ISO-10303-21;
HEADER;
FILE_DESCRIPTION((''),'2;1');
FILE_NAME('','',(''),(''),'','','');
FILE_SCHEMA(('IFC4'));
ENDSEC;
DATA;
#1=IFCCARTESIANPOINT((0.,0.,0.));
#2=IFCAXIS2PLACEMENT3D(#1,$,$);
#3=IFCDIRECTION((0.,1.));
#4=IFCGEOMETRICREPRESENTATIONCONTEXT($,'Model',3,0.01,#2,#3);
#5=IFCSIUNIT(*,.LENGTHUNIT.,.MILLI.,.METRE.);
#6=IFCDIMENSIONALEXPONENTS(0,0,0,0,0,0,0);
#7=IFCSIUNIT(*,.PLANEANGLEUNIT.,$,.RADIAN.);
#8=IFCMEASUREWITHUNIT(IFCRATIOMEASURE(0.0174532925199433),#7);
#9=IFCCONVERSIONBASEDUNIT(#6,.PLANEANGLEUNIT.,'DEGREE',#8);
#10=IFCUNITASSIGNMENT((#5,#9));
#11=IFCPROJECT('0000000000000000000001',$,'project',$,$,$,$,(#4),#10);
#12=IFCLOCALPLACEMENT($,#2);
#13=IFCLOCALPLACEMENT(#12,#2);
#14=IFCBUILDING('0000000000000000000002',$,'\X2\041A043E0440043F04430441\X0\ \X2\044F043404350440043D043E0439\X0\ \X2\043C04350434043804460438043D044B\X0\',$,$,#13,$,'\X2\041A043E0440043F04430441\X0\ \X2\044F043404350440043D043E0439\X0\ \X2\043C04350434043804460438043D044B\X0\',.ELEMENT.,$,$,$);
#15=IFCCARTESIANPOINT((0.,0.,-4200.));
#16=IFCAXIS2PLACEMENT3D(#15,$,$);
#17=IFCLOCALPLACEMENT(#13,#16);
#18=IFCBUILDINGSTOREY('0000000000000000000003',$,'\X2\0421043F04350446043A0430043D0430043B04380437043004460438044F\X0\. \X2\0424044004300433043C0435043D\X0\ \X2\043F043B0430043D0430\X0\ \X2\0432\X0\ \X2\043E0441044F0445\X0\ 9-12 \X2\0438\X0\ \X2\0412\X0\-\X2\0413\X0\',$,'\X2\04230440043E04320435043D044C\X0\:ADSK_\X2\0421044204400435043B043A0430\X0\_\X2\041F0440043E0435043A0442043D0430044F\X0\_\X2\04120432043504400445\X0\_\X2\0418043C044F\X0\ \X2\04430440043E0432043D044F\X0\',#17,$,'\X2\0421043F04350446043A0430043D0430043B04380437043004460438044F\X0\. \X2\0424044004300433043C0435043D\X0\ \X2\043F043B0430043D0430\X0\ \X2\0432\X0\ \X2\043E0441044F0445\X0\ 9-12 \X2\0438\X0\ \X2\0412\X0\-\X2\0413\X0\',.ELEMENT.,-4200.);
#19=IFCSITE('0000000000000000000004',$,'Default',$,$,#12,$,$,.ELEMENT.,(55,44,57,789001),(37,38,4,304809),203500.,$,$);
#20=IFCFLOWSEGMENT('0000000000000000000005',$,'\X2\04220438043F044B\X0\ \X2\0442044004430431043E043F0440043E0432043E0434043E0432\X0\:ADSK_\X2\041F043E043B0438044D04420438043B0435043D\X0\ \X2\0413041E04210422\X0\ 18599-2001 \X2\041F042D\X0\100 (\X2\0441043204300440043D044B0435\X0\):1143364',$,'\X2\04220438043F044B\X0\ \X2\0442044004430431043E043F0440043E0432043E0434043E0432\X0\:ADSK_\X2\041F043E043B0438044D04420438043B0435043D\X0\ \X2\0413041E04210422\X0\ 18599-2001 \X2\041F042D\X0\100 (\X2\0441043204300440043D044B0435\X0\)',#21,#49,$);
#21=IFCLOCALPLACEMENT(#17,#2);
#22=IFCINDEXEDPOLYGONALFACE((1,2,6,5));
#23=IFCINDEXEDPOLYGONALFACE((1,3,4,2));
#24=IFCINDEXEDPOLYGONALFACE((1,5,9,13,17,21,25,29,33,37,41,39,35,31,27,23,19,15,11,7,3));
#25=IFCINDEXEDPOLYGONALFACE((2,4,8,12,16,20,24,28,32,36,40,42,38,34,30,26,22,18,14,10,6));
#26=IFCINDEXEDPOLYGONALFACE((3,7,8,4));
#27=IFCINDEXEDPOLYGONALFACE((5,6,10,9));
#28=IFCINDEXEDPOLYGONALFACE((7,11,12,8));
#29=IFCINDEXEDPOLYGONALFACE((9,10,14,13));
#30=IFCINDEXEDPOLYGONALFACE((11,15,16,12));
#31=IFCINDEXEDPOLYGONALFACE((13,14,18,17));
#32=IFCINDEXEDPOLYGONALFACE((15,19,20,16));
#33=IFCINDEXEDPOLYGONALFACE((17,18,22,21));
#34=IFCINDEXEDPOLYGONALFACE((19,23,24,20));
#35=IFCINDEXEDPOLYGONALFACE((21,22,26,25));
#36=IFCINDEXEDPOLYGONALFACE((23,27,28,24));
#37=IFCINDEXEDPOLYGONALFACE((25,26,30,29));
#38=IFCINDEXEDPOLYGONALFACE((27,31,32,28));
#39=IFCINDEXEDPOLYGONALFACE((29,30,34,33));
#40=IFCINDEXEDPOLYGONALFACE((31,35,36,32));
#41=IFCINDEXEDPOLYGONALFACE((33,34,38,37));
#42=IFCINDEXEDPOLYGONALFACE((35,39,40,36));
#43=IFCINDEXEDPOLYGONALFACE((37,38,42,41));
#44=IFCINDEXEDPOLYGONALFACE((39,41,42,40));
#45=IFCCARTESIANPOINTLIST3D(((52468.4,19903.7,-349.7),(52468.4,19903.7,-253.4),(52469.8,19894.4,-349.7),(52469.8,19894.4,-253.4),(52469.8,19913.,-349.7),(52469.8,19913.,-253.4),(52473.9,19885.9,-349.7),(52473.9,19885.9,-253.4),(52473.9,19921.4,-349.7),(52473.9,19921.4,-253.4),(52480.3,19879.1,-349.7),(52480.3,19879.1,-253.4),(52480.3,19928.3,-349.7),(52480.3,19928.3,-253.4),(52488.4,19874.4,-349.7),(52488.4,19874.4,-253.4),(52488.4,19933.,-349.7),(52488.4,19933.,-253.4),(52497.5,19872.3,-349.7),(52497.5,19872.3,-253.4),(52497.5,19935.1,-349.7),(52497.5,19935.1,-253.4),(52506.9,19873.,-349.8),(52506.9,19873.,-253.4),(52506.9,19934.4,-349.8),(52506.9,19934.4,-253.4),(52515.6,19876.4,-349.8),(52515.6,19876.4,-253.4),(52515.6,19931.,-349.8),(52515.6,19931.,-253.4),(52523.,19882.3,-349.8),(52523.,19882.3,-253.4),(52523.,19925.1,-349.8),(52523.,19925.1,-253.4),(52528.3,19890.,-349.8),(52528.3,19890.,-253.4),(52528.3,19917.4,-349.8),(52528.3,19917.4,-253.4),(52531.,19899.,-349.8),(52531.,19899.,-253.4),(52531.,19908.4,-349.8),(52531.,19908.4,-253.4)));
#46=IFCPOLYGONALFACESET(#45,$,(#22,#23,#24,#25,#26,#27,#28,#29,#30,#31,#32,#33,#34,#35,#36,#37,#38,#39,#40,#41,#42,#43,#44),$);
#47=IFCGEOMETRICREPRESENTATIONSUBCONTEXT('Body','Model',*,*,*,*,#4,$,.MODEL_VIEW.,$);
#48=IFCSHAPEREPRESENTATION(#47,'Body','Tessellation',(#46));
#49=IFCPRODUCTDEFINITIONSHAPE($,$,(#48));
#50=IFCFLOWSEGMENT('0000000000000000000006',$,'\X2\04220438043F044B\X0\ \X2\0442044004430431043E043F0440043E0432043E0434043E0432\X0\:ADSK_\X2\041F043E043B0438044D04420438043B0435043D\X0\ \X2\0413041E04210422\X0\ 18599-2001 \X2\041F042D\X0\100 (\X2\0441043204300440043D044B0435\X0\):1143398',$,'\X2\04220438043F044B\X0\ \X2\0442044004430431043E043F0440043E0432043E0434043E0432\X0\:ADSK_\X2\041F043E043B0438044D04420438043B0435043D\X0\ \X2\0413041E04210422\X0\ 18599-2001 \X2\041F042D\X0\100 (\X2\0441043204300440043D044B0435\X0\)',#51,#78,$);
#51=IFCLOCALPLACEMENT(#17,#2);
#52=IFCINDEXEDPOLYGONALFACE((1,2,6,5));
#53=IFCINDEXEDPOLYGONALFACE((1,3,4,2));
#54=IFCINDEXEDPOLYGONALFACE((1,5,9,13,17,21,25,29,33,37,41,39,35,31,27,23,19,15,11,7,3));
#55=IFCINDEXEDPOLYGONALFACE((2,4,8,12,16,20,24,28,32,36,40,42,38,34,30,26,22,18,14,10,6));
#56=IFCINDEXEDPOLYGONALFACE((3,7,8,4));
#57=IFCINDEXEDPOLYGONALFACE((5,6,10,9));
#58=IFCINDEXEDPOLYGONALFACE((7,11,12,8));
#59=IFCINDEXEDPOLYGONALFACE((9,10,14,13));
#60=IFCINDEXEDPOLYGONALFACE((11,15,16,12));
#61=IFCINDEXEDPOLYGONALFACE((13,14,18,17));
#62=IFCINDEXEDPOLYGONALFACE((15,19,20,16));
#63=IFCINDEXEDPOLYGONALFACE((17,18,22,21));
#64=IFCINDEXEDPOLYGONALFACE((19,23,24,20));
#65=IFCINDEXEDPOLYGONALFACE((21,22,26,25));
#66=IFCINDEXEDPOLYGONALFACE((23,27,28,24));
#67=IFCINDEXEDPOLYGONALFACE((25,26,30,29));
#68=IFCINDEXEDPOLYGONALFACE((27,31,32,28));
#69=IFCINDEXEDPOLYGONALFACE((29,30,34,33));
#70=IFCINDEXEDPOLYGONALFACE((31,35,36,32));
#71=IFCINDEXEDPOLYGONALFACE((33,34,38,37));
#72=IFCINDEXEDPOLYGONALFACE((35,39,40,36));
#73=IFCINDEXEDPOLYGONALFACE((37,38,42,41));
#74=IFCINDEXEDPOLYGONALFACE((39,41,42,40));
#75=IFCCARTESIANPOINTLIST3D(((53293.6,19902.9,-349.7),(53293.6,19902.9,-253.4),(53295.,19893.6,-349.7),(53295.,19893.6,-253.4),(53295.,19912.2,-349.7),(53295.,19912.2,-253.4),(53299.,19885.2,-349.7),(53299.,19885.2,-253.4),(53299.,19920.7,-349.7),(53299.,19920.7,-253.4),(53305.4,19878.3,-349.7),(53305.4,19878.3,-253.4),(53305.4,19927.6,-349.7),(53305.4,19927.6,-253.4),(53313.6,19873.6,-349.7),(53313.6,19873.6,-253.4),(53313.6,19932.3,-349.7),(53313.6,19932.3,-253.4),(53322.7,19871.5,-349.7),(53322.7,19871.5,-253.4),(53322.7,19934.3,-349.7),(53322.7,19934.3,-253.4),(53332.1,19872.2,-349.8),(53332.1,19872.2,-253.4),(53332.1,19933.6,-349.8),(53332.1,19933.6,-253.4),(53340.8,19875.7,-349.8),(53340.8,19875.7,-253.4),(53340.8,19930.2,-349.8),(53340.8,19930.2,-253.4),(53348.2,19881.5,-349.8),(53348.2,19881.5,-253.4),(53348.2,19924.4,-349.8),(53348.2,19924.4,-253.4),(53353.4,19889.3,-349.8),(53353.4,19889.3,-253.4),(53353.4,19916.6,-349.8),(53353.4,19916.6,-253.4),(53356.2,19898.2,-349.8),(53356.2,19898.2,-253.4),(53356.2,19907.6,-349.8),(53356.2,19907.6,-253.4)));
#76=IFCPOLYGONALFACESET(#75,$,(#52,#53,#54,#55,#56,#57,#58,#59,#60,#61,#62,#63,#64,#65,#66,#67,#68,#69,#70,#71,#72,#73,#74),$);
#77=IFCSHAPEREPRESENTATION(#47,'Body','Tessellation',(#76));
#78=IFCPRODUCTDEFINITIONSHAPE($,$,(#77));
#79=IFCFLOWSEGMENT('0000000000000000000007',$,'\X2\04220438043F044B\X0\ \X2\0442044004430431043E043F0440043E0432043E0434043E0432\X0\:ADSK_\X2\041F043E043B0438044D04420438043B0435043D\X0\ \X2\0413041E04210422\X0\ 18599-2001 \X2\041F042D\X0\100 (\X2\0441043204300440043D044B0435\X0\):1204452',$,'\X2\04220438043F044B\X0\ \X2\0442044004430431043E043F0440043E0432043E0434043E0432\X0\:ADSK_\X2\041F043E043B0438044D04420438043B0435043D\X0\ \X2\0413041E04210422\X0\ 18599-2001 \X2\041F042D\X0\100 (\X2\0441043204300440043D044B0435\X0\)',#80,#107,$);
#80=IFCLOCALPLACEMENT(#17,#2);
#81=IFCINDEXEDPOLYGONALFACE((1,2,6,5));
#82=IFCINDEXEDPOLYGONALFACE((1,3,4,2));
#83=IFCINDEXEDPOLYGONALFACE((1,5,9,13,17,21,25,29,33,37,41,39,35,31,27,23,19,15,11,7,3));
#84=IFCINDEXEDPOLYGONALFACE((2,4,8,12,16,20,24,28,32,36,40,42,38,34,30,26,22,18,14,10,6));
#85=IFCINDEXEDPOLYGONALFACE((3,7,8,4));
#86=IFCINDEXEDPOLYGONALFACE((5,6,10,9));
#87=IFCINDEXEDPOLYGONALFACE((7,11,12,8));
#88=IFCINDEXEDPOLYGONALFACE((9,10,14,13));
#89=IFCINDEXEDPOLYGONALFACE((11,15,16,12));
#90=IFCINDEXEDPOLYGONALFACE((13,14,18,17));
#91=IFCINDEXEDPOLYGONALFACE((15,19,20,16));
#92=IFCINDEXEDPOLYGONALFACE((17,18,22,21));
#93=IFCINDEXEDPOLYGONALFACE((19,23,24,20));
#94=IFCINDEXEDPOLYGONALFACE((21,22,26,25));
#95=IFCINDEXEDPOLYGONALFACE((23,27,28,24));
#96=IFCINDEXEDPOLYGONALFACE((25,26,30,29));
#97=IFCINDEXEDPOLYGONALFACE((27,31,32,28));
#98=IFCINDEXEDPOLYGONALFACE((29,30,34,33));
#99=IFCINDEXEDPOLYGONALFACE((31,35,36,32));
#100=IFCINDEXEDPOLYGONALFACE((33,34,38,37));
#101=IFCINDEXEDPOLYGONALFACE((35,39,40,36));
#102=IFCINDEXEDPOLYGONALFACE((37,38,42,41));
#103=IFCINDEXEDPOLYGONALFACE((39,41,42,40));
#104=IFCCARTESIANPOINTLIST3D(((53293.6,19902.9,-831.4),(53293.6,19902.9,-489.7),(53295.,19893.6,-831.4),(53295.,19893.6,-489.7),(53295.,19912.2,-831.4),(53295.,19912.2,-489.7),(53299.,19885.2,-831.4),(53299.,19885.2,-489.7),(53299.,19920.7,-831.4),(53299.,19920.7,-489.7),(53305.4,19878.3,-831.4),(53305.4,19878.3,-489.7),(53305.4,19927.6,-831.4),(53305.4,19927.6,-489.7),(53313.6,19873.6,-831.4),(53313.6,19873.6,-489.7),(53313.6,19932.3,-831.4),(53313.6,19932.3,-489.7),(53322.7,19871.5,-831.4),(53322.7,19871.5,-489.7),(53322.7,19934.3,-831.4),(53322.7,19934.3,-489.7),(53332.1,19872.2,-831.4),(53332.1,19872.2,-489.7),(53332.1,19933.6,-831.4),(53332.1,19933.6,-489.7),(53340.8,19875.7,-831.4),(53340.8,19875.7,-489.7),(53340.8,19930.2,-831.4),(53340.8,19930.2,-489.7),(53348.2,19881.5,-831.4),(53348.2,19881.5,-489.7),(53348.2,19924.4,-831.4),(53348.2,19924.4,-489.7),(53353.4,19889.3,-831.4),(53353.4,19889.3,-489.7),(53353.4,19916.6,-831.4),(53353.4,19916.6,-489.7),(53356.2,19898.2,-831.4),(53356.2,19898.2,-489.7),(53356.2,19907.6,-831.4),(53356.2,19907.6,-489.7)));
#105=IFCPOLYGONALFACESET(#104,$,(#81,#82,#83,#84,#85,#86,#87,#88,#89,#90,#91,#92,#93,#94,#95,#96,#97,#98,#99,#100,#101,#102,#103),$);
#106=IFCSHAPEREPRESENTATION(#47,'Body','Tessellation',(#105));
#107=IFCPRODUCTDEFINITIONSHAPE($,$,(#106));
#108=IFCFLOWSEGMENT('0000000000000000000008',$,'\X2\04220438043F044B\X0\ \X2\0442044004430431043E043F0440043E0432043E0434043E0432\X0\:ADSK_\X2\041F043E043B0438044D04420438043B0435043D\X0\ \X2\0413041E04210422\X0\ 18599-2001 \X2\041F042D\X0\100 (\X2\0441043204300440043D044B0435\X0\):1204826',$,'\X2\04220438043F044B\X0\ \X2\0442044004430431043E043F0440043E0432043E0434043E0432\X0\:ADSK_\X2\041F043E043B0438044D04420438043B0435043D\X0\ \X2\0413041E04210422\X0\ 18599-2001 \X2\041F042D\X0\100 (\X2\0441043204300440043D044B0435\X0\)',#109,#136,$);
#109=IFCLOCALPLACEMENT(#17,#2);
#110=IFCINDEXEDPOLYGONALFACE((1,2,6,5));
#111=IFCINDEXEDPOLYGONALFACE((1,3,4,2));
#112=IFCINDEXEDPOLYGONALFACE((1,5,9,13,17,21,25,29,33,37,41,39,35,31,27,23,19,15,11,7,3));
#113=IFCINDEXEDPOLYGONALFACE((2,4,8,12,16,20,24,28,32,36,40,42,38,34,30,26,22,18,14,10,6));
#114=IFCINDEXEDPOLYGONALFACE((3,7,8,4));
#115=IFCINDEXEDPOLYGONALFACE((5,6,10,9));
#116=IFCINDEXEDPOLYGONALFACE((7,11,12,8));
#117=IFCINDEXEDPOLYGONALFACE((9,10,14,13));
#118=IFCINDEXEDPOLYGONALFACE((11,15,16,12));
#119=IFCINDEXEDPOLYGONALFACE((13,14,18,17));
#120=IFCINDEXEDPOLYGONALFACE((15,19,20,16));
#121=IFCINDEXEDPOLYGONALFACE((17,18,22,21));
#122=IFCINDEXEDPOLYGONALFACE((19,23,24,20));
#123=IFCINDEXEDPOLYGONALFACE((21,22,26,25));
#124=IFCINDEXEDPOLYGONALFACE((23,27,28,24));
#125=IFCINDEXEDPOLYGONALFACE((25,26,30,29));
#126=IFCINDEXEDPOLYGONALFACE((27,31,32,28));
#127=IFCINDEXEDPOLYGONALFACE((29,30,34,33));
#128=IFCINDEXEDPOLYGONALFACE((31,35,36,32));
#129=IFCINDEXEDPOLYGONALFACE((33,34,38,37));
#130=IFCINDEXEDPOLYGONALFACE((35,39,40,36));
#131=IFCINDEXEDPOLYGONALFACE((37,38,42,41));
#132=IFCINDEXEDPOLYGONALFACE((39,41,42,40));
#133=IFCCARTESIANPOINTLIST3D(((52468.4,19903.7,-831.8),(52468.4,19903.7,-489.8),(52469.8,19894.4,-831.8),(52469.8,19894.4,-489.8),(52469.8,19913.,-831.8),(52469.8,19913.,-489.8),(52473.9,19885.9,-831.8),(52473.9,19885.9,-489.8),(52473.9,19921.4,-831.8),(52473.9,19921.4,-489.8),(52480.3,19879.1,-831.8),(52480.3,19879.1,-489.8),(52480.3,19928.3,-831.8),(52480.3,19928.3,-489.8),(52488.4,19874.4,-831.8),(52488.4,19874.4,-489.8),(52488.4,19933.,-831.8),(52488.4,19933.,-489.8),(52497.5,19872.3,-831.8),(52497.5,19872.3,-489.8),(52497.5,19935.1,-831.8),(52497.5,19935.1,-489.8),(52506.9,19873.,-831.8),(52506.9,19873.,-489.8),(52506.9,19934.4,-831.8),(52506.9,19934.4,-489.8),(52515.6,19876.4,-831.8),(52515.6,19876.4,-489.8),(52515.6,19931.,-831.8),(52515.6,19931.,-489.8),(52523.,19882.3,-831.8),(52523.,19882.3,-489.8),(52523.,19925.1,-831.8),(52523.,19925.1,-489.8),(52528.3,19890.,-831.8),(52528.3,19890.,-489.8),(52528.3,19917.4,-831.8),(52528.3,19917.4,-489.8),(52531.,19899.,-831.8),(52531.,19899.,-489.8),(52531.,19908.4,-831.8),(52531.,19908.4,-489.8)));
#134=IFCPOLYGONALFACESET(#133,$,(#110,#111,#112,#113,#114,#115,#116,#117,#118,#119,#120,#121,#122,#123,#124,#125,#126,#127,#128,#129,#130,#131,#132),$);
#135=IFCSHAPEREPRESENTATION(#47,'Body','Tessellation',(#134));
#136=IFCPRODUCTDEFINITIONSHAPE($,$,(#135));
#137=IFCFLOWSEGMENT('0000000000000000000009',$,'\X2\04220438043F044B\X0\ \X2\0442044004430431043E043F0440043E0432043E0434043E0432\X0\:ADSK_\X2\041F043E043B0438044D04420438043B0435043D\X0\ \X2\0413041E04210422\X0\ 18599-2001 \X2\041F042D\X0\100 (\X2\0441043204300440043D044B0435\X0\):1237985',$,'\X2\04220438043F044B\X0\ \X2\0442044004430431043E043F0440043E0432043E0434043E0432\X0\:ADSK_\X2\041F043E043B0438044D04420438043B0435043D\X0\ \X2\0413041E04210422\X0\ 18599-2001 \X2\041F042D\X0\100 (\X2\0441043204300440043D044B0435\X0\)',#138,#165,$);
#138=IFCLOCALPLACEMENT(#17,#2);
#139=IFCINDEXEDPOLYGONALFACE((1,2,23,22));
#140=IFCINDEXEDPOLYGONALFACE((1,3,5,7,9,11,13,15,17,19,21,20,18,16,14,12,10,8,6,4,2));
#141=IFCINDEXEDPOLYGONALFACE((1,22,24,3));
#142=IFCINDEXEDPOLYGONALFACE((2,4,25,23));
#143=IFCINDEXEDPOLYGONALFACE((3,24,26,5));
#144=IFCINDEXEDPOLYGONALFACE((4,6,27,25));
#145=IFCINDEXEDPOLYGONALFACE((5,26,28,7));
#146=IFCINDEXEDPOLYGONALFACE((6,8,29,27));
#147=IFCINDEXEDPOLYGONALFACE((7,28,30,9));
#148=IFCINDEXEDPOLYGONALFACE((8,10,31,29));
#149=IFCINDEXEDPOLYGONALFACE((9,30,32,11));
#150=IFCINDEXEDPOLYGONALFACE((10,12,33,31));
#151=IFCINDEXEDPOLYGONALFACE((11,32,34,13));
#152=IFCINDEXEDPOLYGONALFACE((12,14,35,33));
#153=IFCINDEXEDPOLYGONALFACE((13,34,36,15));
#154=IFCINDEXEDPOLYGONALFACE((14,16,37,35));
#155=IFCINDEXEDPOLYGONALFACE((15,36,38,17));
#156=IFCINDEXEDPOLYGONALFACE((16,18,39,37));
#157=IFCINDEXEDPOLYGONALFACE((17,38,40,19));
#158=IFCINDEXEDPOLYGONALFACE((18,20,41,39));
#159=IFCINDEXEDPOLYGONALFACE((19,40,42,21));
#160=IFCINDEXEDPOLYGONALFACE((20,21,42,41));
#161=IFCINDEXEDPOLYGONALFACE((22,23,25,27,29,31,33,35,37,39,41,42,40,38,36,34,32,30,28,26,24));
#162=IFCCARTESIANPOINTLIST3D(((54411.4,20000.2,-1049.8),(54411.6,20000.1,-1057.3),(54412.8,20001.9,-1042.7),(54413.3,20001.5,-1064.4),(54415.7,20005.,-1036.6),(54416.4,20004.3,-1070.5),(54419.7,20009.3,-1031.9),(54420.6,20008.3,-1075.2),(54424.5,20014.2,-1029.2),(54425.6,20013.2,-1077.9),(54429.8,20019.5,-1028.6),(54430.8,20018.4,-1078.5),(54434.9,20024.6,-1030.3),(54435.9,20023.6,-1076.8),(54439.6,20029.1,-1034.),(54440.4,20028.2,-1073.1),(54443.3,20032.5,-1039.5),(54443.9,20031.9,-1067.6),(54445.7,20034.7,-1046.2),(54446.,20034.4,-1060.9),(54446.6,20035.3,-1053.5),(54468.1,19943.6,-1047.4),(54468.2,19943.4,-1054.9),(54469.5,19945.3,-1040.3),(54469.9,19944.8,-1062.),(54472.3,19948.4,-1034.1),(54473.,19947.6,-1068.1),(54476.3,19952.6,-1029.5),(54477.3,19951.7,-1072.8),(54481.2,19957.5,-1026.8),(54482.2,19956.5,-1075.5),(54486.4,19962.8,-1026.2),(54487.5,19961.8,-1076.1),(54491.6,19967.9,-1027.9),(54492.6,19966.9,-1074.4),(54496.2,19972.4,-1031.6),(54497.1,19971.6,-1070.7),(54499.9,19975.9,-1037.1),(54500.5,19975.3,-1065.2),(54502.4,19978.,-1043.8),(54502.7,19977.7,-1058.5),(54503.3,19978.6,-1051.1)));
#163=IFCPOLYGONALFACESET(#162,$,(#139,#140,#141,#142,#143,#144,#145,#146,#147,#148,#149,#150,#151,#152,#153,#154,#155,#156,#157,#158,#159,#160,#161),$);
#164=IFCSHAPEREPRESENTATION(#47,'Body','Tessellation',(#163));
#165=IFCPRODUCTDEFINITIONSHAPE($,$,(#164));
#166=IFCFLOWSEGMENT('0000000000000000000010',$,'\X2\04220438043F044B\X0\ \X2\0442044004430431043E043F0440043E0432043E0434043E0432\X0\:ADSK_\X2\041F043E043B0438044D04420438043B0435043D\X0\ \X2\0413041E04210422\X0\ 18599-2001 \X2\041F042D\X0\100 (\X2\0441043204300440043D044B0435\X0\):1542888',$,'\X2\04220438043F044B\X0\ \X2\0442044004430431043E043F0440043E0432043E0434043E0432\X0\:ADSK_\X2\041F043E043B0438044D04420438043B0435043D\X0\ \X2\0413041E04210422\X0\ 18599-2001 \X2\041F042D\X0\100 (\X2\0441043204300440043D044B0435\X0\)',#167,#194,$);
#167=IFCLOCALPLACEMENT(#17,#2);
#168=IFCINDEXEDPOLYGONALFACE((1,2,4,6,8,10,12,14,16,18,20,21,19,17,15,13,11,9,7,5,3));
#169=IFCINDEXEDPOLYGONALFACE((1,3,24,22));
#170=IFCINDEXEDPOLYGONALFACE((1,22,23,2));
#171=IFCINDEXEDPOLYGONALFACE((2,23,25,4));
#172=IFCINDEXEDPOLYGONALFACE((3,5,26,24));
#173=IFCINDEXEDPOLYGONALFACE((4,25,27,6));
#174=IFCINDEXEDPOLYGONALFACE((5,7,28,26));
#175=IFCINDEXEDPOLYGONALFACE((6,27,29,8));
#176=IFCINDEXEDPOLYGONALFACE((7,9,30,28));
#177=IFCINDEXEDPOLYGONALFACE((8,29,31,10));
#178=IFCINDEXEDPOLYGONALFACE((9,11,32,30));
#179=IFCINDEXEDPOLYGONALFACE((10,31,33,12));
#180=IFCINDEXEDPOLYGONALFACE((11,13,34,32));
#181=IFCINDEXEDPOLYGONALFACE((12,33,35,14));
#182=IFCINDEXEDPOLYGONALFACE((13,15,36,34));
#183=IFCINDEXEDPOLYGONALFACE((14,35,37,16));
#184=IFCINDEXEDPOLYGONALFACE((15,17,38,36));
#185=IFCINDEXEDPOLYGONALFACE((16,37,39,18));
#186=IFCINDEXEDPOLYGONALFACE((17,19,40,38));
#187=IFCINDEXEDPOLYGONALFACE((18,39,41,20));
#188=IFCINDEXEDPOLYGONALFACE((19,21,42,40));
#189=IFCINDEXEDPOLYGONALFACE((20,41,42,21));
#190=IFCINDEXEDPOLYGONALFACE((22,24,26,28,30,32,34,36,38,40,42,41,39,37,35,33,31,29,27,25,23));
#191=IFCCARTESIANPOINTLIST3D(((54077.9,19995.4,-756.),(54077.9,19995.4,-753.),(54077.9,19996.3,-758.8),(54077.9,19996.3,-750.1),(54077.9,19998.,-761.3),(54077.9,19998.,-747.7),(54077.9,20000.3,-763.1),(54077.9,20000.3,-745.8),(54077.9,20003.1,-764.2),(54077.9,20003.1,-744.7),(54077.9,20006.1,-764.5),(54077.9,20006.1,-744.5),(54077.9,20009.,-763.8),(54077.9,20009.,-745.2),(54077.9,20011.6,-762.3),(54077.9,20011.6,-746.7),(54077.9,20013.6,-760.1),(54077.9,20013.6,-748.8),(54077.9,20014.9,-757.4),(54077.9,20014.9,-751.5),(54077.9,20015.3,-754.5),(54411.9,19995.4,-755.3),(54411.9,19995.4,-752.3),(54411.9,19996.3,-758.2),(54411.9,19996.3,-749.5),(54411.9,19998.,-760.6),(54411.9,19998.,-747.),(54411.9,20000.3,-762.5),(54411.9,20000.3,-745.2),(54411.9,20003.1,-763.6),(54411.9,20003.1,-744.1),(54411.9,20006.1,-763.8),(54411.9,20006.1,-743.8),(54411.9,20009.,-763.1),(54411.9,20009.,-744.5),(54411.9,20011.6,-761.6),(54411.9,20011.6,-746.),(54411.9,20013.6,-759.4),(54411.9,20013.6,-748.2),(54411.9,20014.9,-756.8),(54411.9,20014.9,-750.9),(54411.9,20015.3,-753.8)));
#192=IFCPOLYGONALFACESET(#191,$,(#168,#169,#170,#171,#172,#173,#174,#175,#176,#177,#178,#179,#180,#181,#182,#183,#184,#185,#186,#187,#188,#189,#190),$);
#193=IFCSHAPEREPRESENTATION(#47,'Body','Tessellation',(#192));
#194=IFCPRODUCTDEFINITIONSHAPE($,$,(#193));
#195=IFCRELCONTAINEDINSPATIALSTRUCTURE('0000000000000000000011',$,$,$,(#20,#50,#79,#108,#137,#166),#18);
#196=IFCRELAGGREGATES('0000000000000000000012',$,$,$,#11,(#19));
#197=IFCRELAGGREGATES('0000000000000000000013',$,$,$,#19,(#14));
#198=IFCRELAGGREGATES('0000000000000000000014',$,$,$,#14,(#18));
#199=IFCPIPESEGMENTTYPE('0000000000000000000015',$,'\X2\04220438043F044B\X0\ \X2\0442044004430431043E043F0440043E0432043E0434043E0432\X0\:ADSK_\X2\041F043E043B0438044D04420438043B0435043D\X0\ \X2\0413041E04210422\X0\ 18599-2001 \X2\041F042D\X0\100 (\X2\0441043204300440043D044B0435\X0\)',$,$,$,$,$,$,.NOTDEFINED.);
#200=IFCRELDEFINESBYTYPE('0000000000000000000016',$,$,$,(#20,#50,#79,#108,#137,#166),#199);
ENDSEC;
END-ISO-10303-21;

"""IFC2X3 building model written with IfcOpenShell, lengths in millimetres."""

from ifc_helpers import new_model, entity, si_unit, converted_unit, direction, frame, origin, origin_2d_with_axis, place, context, subcontext, project, spatial, circle, extrude, type_object, element, save


model = new_model("IFC2X3")

# Units and contexts
model_context = context("Model", 3, precision=0.01, world=origin(), true_north=direction((0.0, 1.0)))
body_context = subcontext(model_context, "Body", "Model", "MODEL_VIEW")
ifc_project = project(units=[si_unit("LENGTHUNIT", "METRE", prefix="MILLI"), converted_unit("PLANEANGLEUNIT", "DEGREE", entity("IfcRatioMeasure", 0.0174532925199433), si_unit("PLANEANGLEUNIT", "RADIAN"), dimensions=[0, 0, 0, 0, 0, 0, 0])], contexts=[model_context])

# Site, building, storey
site_placement = place(None, origin())
site = spatial("IfcSite", under=ifc_project, at=site_placement, Name="Default", CompositionType="ELEMENT", RefLatitude=(55, 44, 57, 789001), RefLongitude=(37, 38, 4, 304809), RefElevation=203500.0)
building_placement = place(site_placement, origin())
building = spatial("IfcBuilding", under=site, at=building_placement, Name="Корпус ядерной медицины", LongName="Корпус ядерной медицины", CompositionType="ELEMENT")
storey_placement = place(building_placement, frame((0.0, 0.0, -4200.0)))
storey = spatial("IfcBuildingStorey", under=building, at=storey_placement, Name="Спецканализация. Фрагмен плана в осях 9-12 и В-Г", ObjectType="Уровень:ADSK_Стрелка_Проектная_Вверх_Имя уровня", LongName="Спецканализация. Фрагмен плана в осях 9-12 и В-Г", CompositionType="ELEMENT", Elevation=-4200.0)

# Flow segments
pipe_segment_type = type_object("IfcPipeSegmentType", Name="Типы трубопроводов:ADSK_Полиэтилен ГОСТ 18599-2001 ПЭ100 (сварные)", PredefinedType="NOTDEFINED")
flow_segment_1_placement = place(storey_placement, frame((52466.8, 19870.6, -349.8)))
element("IfcFlowSegment", 1, at=flow_segment_1_placement, inside=storey, type_object=pipe_segment_type, Name="Типы трубопроводов:ADSK_Полиэтилен ГОСТ 18599-2001 ПЭ100 (сварные):1143364", ObjectType="Типы трубопроводов:ADSK_Полиэтилен ГОСТ 18599-2001 ПЭ100 (сварные)", context=body_context, shape_type="SweptSolid", body=[
    extrude(circle(Radius=31.5, at=origin_2d_with_axis()), frame((33.1, 33.1, 0.0), z_axis=(0.000001, 0.0, 1.0), x_axis=(-1.0, 0.0, 0.000001)), (0.0, 0.0, 1.0), 96.3),
])
flow_segment_2_placement = place(storey_placement, frame((53292.0, 19869.8, -349.8)))
element("IfcFlowSegment", 2, at=flow_segment_2_placement, inside=storey, type_object=pipe_segment_type, Name="Типы трубопроводов:ADSK_Полиэтилен ГОСТ 18599-2001 ПЭ100 (сварные):1143398", ObjectType="Типы трубопроводов:ADSK_Полиэтилен ГОСТ 18599-2001 ПЭ100 (сварные)", context=body_context, shape_type="SweptSolid", body=[
    extrude(circle(Radius=31.5, at=origin_2d_with_axis()), frame((33.1, 33.1, 0.0), z_axis=(0.000001, 0.0, 1.0), x_axis=(-1.0, 0.0, 0.000001)), (0.0, 0.0, 1.0), 96.3),
])
flow_segment_3_placement = place(storey_placement, frame((53292.0, 19869.8, -831.4)))
element("IfcFlowSegment", 3, at=flow_segment_3_placement, inside=storey, type_object=pipe_segment_type, Name="Типы трубопроводов:ADSK_Полиэтилен ГОСТ 18599-2001 ПЭ100 (сварные):1204452", ObjectType="Типы трубопроводов:ADSK_Полиэтилен ГОСТ 18599-2001 ПЭ100 (сварные)", context=body_context, shape_type="SweptSolid", body=[
    extrude(circle(Radius=31.5, at=origin_2d_with_axis()), frame((33.1, 33.1, 0.0), z_axis=(0.000002, 0.0, 1.0), x_axis=(-1.0, 0.0, 0.000002)), (0.0, 0.0, 1.0), 341.7),
])
flow_segment_4_placement = place(storey_placement, frame((52466.8, 19870.6, -831.8)))
element("IfcFlowSegment", 4, at=flow_segment_4_placement, inside=storey, type_object=pipe_segment_type, Name="Типы трубопроводов:ADSK_Полиэтилен ГОСТ 18599-2001 ПЭ100 (сварные):1204826", ObjectType="Типы трубопроводов:ADSK_Полиэтилен ГОСТ 18599-2001 ПЭ100 (сварные)", context=body_context, shape_type="SweptSolid", body=[
    extrude(circle(Radius=31.5, at=origin_2d_with_axis()), frame((33.1, 33.1, 0.0), z_axis=(0.000002, 0.0, 1.0), x_axis=(-1.0, 0.0, 0.000002)), (0.0, 0.0, 1.0), 342.0),
])
flow_segment_5_placement = place(storey_placement, frame((54409.7, 19941.7, -1080.1)))
element("IfcFlowSegment", 5, at=flow_segment_5_placement, inside=storey, type_object=pipe_segment_type, Name="Типы трубопроводов:ADSK_Полиэтилен ГОСТ 18599-2001 ПЭ100 (сварные):1237985", ObjectType="Типы трубопроводов:ADSK_Полиэтилен ГОСТ 18599-2001 ПЭ100 (сварные)", context=body_context, shape_type="SweptSolid", body=[
    extrude(circle(Radius=25.0, at=origin_2d_with_axis()), frame((19.3, 75.9, 26.6), z_axis=(0.706789, -0.706789, 0.029987), x_axis=(0.707107, 0.707107, 0.0)), (0.0, 0.0, 1.0), 80.2),
])
flow_segment_6_placement = place(storey_placement, frame((54077.9, 19993.7, -766.1)))
element("IfcFlowSegment", 6, at=flow_segment_6_placement, inside=storey, type_object=pipe_segment_type, Name="Типы трубопроводов:ADSK_Полиэтилен ГОСТ 18599-2001 ПЭ100 (сварные):1542888", ObjectType="Типы трубопроводов:ADSK_Полиэтилен ГОСТ 18599-2001 ПЭ100 (сварные)", context=body_context, shape_type="SweptSolid", body=[
    extrude(circle(Radius=10.0, at=origin_2d_with_axis()), frame((0.0, 11.6, 11.6), z_axis=(0.999998, 0.0, 0.002), x_axis=(0.0, 1.0, 0.0)), (0.0, 0.0, 1.0), 334.0),
])

save(model, "model.ifc")
